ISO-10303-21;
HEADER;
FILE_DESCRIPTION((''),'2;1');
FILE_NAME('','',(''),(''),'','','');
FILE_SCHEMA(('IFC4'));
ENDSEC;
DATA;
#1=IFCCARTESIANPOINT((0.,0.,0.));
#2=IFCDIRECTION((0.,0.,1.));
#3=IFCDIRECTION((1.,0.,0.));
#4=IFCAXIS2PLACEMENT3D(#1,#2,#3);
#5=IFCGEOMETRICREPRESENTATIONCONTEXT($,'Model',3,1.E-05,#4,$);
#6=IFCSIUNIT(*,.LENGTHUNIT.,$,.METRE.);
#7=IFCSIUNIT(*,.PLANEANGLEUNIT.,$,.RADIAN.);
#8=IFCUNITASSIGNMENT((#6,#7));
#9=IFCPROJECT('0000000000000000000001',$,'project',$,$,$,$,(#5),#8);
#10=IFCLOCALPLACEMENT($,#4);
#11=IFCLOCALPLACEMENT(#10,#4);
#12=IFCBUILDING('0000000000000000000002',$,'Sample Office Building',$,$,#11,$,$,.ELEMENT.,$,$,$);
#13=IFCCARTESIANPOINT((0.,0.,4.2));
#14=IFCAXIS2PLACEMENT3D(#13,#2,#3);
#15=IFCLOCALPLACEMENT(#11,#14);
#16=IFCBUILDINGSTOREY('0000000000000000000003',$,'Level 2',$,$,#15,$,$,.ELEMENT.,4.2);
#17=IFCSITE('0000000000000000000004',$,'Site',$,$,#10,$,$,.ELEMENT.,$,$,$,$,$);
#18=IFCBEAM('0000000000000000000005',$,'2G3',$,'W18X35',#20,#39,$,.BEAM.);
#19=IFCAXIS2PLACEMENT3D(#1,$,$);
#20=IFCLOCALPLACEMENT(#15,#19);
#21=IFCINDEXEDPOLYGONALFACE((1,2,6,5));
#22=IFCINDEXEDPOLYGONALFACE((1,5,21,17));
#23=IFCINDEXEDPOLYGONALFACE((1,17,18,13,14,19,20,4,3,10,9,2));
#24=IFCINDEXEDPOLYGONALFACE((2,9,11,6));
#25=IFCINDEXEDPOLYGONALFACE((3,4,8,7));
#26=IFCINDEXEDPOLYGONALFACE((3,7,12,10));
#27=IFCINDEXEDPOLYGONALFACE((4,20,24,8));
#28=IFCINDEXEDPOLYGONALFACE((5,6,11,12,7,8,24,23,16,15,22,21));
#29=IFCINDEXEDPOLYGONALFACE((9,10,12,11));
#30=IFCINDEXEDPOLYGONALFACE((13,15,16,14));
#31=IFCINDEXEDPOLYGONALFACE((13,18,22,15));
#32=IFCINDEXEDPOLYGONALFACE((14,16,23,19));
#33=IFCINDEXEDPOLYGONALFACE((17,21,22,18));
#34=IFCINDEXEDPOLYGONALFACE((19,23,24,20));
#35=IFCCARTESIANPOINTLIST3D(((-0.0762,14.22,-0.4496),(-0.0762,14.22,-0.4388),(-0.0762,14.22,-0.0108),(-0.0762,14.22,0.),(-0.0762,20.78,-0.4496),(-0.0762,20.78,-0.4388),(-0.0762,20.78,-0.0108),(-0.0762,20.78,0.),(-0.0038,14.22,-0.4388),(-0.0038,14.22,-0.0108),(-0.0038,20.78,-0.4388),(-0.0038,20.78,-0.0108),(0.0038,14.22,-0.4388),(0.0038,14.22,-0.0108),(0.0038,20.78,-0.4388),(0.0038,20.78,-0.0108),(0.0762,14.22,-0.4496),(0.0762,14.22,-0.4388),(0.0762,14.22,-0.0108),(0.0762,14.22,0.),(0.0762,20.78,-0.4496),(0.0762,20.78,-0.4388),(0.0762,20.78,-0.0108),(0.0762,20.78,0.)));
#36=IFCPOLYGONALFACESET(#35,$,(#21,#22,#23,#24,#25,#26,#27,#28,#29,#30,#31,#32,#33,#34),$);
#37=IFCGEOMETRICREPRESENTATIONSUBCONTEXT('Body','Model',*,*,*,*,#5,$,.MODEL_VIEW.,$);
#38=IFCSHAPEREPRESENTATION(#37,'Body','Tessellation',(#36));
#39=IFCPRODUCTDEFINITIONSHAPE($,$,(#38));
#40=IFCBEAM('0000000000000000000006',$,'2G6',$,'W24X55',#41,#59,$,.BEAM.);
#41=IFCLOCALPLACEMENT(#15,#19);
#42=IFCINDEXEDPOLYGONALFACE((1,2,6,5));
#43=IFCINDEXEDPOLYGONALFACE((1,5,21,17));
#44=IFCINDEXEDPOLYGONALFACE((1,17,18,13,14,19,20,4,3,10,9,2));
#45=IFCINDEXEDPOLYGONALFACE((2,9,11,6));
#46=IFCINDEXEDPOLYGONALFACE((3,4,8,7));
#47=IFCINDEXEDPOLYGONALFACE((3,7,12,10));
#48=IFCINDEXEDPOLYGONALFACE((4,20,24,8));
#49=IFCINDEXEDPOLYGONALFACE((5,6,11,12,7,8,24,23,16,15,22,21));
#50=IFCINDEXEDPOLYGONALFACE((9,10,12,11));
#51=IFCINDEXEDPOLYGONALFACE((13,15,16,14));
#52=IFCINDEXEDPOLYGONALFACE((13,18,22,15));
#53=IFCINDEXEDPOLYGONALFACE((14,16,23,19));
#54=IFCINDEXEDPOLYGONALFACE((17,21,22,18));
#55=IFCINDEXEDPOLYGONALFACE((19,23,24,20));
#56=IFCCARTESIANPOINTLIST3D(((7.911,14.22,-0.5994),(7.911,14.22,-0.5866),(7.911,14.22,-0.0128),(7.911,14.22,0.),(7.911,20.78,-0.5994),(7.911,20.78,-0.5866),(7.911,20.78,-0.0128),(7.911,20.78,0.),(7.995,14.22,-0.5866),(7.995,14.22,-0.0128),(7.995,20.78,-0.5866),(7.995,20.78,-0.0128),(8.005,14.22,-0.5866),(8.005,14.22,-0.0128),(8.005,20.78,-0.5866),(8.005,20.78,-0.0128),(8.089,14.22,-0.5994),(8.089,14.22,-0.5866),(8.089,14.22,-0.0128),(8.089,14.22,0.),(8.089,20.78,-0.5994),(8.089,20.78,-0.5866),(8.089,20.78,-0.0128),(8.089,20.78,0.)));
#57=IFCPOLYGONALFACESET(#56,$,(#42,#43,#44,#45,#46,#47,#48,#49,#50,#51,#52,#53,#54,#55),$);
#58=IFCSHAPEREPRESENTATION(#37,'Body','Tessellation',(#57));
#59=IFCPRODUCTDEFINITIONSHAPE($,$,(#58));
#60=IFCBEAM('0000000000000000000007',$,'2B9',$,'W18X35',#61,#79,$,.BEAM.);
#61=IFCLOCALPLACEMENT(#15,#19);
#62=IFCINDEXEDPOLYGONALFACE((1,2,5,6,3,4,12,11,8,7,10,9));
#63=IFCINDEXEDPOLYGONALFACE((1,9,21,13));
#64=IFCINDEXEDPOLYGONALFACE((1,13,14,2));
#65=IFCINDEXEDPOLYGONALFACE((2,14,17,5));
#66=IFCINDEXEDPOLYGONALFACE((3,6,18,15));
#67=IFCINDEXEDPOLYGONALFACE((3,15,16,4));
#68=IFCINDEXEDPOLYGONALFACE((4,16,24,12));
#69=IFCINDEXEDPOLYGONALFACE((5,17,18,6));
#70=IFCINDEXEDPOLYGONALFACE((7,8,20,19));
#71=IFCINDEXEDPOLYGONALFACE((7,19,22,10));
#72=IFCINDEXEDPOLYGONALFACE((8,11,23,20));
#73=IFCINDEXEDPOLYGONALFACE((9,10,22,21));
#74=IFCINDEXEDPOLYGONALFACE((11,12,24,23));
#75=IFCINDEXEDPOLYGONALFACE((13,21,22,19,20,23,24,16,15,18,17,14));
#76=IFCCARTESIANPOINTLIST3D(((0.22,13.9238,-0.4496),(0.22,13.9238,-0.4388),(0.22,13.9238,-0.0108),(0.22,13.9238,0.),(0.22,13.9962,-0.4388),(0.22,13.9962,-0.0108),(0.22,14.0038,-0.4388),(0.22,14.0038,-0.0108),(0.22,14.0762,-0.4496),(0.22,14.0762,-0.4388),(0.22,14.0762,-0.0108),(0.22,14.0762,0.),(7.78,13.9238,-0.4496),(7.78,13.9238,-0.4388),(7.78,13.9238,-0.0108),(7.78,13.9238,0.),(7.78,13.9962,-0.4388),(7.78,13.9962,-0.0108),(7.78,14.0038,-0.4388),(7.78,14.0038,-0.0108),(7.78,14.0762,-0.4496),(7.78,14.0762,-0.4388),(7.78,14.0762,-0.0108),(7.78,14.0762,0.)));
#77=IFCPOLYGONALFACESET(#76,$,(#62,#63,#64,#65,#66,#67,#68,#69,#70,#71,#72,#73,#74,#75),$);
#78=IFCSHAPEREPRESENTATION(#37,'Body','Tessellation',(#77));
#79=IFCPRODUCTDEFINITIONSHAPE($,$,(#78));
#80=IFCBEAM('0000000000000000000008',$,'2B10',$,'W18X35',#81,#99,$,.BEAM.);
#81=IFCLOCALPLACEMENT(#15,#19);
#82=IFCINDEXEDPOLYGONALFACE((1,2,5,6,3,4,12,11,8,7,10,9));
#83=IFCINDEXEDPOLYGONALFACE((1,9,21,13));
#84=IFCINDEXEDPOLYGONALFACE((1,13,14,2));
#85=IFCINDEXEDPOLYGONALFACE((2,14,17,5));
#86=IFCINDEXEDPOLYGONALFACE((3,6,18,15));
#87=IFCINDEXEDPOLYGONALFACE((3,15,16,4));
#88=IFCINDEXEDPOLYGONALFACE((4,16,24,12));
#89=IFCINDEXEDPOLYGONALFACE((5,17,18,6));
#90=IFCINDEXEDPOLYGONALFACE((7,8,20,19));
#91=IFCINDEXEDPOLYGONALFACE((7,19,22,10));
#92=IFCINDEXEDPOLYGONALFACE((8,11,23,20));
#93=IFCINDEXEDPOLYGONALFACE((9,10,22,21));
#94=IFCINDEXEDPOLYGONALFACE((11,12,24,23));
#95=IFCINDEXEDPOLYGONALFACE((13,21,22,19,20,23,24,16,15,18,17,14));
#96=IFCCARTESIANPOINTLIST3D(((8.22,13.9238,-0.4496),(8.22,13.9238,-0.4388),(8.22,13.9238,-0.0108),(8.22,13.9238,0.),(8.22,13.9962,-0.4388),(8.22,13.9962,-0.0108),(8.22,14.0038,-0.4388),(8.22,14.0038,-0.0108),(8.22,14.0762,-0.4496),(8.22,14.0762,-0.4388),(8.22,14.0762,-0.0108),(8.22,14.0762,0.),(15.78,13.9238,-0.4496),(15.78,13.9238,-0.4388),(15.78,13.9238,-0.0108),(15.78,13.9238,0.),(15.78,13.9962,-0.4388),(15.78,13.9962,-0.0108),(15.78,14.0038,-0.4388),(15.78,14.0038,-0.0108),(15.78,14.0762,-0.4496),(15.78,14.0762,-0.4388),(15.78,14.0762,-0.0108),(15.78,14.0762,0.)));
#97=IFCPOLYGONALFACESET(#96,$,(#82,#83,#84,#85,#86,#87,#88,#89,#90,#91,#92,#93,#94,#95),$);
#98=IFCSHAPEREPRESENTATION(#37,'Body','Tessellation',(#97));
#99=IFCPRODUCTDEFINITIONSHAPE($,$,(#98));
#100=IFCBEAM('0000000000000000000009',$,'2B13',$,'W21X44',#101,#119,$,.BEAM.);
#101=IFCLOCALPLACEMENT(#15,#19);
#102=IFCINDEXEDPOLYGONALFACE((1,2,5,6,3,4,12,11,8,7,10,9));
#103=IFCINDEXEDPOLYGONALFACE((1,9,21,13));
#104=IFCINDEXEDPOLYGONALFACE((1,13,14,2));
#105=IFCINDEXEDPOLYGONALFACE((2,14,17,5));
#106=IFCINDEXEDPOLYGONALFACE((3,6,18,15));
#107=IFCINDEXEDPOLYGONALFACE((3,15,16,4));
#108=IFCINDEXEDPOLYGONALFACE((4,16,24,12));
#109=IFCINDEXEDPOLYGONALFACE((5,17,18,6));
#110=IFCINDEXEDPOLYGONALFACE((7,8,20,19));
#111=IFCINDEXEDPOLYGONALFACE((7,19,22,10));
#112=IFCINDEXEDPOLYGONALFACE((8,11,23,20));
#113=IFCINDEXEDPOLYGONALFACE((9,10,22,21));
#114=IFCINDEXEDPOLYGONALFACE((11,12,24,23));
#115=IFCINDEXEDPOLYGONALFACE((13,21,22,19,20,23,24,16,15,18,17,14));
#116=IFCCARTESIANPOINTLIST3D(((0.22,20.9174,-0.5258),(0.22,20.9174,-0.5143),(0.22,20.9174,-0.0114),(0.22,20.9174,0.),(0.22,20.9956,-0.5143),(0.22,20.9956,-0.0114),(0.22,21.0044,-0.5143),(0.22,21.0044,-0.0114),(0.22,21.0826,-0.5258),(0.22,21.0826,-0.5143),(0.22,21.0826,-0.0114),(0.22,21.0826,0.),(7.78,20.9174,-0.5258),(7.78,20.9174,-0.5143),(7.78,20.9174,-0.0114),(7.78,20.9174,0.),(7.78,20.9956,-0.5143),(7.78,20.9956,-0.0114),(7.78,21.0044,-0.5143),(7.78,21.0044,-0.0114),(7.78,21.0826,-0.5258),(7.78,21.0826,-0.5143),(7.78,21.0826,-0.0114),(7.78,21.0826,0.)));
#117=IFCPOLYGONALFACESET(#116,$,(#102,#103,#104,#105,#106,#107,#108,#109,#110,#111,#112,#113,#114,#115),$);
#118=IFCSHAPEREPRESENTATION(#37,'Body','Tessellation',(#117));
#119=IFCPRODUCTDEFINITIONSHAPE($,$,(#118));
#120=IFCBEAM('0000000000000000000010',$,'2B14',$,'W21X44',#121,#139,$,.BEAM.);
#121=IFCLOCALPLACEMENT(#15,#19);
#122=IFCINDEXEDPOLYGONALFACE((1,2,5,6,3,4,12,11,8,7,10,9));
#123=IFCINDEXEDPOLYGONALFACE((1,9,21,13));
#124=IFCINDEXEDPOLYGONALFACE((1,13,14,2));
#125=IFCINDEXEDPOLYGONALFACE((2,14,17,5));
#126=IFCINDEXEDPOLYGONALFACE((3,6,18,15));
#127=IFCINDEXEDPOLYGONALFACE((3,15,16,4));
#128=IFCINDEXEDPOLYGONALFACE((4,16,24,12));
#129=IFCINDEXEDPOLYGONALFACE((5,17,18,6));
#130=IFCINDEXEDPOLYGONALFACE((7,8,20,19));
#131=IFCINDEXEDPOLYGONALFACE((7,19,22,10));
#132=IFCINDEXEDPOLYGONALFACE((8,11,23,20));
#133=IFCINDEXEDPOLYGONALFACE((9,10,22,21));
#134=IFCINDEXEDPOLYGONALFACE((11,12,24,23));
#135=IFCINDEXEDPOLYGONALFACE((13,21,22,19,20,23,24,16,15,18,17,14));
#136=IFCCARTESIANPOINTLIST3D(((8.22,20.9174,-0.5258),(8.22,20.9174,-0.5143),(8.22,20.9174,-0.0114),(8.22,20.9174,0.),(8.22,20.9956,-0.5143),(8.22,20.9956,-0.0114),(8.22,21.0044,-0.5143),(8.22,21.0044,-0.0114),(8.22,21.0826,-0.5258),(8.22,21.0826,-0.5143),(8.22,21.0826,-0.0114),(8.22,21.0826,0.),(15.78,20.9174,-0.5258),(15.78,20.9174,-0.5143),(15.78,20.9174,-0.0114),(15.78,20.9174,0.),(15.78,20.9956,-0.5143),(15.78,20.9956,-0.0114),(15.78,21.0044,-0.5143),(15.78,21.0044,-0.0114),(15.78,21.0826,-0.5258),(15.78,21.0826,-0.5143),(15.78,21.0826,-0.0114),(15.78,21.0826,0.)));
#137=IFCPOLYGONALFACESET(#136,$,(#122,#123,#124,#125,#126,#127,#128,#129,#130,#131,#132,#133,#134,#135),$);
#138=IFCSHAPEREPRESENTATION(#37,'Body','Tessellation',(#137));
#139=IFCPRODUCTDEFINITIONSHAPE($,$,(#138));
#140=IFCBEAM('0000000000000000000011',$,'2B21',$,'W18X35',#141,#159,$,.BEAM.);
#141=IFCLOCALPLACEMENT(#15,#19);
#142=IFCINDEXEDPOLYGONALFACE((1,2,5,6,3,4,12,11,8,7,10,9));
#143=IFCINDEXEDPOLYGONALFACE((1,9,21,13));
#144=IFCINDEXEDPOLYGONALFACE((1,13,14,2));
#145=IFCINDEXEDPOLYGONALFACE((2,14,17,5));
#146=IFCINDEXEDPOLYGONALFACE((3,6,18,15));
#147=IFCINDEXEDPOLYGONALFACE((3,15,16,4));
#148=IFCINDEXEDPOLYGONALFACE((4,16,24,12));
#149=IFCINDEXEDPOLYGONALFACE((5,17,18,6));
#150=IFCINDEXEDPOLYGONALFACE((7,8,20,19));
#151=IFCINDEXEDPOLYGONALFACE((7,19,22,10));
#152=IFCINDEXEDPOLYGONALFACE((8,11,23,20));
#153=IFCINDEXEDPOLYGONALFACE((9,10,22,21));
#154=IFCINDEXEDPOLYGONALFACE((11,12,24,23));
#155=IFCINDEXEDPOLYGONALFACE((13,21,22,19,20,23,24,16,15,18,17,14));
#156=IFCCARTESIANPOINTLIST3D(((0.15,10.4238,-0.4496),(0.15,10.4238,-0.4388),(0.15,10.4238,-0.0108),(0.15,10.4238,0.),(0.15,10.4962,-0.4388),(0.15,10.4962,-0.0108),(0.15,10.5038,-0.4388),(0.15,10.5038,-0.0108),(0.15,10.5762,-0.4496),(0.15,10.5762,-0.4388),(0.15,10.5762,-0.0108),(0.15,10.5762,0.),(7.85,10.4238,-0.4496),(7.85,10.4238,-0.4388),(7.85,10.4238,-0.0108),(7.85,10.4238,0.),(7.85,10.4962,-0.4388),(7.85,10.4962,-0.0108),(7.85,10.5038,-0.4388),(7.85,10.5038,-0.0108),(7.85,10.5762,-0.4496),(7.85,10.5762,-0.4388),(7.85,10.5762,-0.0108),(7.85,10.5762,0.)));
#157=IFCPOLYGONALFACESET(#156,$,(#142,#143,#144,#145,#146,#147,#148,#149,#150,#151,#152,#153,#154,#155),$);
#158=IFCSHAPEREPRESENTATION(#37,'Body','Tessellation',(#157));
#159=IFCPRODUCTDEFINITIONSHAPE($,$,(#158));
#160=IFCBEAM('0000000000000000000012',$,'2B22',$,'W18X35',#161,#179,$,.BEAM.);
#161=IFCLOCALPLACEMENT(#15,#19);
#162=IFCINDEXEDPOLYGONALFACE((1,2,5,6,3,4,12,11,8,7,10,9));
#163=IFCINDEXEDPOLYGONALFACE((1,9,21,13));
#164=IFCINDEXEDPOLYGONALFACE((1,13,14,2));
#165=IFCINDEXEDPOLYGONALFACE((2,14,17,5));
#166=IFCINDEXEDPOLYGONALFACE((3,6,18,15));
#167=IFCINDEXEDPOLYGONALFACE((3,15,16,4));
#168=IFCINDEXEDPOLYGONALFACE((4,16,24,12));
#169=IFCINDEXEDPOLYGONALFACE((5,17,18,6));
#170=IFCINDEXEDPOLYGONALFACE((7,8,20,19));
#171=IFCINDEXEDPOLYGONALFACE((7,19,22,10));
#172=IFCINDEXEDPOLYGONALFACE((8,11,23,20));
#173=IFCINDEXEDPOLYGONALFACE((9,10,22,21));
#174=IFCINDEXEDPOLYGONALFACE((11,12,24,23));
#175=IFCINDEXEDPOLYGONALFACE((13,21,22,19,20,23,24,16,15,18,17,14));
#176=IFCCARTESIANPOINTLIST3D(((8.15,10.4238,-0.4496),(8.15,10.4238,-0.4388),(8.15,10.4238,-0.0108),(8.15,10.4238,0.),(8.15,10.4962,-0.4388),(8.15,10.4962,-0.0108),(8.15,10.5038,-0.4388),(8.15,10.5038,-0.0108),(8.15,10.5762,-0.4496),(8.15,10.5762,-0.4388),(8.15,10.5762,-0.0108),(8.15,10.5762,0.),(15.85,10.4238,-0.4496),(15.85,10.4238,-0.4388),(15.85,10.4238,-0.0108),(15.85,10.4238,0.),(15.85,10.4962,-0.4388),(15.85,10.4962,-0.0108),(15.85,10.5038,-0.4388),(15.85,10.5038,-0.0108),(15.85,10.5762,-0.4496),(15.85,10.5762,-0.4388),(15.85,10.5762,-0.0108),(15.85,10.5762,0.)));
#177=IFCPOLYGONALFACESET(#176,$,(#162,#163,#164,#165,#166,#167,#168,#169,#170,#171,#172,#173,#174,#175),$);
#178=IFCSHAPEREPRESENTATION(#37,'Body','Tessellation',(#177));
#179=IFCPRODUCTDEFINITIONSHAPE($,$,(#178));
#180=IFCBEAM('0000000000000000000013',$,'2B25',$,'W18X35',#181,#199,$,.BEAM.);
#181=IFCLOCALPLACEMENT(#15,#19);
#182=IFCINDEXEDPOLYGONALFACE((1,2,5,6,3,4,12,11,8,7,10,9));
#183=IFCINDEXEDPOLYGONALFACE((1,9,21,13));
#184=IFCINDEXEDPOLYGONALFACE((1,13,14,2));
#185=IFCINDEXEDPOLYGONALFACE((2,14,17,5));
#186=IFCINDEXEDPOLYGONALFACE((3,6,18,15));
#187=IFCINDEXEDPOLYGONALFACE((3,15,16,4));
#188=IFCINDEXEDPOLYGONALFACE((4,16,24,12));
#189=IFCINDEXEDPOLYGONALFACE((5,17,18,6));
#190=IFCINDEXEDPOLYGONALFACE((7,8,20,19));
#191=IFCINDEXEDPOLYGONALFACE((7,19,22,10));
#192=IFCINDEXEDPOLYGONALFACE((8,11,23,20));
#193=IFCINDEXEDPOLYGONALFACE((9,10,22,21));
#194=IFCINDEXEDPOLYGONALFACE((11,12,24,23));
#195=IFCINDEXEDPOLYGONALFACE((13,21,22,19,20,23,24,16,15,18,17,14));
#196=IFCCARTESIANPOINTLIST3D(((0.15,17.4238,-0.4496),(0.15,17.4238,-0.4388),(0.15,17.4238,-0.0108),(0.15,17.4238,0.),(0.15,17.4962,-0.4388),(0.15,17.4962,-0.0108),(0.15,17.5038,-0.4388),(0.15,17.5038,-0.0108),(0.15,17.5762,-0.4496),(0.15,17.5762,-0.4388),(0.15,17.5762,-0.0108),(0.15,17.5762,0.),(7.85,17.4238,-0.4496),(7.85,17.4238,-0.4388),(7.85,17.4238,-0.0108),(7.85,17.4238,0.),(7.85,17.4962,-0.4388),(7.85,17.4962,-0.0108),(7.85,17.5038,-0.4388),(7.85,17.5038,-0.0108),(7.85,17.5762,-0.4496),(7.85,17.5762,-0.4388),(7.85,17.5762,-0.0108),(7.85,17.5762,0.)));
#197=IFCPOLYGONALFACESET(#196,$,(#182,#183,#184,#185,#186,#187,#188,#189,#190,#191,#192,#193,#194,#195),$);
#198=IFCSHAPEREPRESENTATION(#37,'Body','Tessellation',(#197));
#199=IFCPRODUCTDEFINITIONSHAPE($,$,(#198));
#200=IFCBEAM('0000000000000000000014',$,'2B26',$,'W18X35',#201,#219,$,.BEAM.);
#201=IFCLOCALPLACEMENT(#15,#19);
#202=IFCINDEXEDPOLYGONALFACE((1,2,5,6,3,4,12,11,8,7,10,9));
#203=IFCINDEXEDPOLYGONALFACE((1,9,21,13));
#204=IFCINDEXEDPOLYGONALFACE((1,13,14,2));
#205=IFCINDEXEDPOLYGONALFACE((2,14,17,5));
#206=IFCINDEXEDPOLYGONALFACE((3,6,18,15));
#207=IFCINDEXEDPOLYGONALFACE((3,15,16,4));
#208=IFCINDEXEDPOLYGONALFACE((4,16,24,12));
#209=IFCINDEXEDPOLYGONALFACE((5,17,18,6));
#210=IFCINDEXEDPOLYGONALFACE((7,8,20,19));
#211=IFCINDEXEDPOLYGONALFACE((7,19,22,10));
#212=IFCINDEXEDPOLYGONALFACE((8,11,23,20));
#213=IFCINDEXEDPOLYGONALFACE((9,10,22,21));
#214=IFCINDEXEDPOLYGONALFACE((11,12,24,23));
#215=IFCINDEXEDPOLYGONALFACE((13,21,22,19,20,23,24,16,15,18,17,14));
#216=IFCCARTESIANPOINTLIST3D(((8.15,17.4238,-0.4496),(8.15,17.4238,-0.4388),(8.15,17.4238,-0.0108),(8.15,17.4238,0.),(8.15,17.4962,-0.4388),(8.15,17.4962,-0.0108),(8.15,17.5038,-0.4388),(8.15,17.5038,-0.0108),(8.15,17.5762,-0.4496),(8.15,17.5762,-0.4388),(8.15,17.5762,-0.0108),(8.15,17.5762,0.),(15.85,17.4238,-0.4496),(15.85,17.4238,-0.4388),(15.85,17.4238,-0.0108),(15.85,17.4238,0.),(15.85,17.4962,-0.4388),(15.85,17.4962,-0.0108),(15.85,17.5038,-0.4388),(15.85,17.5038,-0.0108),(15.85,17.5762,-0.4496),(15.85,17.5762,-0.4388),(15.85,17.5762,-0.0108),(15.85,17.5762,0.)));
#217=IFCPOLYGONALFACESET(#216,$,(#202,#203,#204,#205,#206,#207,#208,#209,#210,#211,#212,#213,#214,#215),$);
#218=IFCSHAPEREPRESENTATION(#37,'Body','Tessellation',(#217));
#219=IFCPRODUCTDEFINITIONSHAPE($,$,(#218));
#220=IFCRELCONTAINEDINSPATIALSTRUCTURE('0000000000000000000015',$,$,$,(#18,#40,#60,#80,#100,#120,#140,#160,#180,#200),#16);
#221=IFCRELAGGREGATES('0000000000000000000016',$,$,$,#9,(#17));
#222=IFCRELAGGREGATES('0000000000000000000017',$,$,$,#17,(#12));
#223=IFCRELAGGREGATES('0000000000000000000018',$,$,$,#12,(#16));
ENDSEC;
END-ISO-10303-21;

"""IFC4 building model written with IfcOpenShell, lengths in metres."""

from ifc_helpers import new_model, si_unit, frame, origin_with_axes, place, context, subcontext, project, spatial, i_section, extrude, element, save


model = new_model("IFC4")

# Units and contexts
model_context = context("Model", 3, precision=1e-05, world=origin_with_axes())
body_context = subcontext(model_context, "Body", "Model", "MODEL_VIEW")
ifc_project = project(units=[si_unit("LENGTHUNIT", "METRE"), si_unit("PLANEANGLEUNIT", "RADIAN")], contexts=[model_context])

# Site, building, storey
site_placement = place(None, origin_with_axes())
site = spatial("IfcSite", under=ifc_project, at=site_placement, Name="Site", CompositionType="ELEMENT")
building_placement = place(site_placement, origin_with_axes())
building = spatial("IfcBuilding", under=site, at=building_placement, Name="Sample Office Building", CompositionType="ELEMENT")
storey_placement = place(building_placement, frame((0.0, 0.0, 4.2), z_axis=(0.0, 0.0, 1.0), x_axis=(1.0, 0.0, 0.0)))
storey = spatial("IfcBuildingStorey", under=building, at=storey_placement, Name="Level 2", CompositionType="ELEMENT", Elevation=4.2)

# Beams
beam_1_placement = place(None, frame((0.0, 14.22, 3.9752), z_axis=(0.0, 1.0, 0.0), x_axis=(-1.0, 0.0, 0.0)))
element("IfcBeam", 1, at=beam_1_placement, inside=storey, Name="2G3", ObjectType="W18X35", PredefinedType="BEAM", context=body_context, shape_type="SweptSolid", body=[
    extrude(i_section(OverallWidth=0.1524, OverallDepth=0.4496, WebThickness=0.0076, FlangeThickness=0.0108), None, (0.0, 0.0, 1.0), 6.56),
])
beam_2_placement = place(None, frame((8.0, 14.22, 3.9003), z_axis=(0.0, 1.0, 0.0), x_axis=(-1.0, 0.0, 0.0)))
element("IfcBeam", 2, at=beam_2_placement, inside=storey, Name="2G6", ObjectType="W24X55", PredefinedType="BEAM", context=body_context, shape_type="SweptSolid", body=[
    extrude(i_section(OverallWidth=0.1781, OverallDepth=0.5994, WebThickness=0.01, FlangeThickness=0.0128), None, (0.0, 0.0, 1.0), 6.56),
])
beam_3_placement = place(None, frame((0.22, 14.0, 3.9752), z_axis=(1.0, 0.0, 0.0), x_axis=(0.0, 1.0, 0.0)))
element("IfcBeam", 3, at=beam_3_placement, inside=storey, Name="2B9", ObjectType="W18X35", PredefinedType="BEAM", context=body_context, shape_type="SweptSolid", body=[
    extrude(i_section(OverallWidth=0.1524, OverallDepth=0.4496, WebThickness=0.0076, FlangeThickness=0.0108), None, (0.0, 0.0, 1.0), 7.56),
])
beam_4_placement = place(None, frame((8.22, 14.0, 3.9752), z_axis=(1.0, 0.0, 0.0), x_axis=(0.0, 1.0, 0.0)))
element("IfcBeam", 4, at=beam_4_placement, inside=storey, Name="2B10", ObjectType="W18X35", PredefinedType="BEAM", context=body_context, shape_type="SweptSolid", body=[
    extrude(i_section(OverallWidth=0.1524, OverallDepth=0.4496, WebThickness=0.0076, FlangeThickness=0.0108), None, (0.0, 0.0, 1.0), 7.56),
])
beam_5_placement = place(None, frame((0.22, 21.0, 3.9371), z_axis=(1.0, 0.0, 0.0), x_axis=(0.0, 1.0, 0.0)))
element("IfcBeam", 5, at=beam_5_placement, inside=storey, Name="2B13", ObjectType="W21X44", PredefinedType="BEAM", context=body_context, shape_type="SweptSolid", body=[
    extrude(i_section(OverallWidth=0.1651, OverallDepth=0.5258, WebThickness=0.0089, FlangeThickness=0.0114), None, (0.0, 0.0, 1.0), 7.56),
])
beam_6_placement = place(None, frame((8.22, 21.0, 3.9371), z_axis=(1.0, 0.0, 0.0), x_axis=(0.0, 1.0, 0.0)))
element("IfcBeam", 6, at=beam_6_placement, inside=storey, Name="2B14", ObjectType="W21X44", PredefinedType="BEAM", context=body_context, shape_type="SweptSolid", body=[
    extrude(i_section(OverallWidth=0.1651, OverallDepth=0.5258, WebThickness=0.0089, FlangeThickness=0.0114), None, (0.0, 0.0, 1.0), 7.56),
])
for number, where, z_axis, x_axis, name in (
    (7, (0.15, 10.5, 3.9752), (1.0, 0.0, 0.0), (0.0, 1.0, 0.0), "2B21"),
    (8, (8.15, 10.5, 3.9752), (1.0, 0.0, 0.0), (0.0, 1.0, 0.0), "2B22"),
    (9, (0.15, 17.5, 3.9752), (1.0, 0.0, 0.0), (0.0, 1.0, 0.0), "2B25"),
    (10, (8.15, 17.5, 3.9752), (1.0, 0.0, 0.0), (0.0, 1.0, 0.0), "2B26"),
):
    element("IfcBeam", number, at=place(None, frame(where, z_axis=z_axis, x_axis=x_axis)), inside=storey, Name=name, ObjectType="W18X35", PredefinedType="BEAM", context=body_context, shape_type="SweptSolid", body=[
        extrude(i_section(OverallWidth=0.1524, OverallDepth=0.4496, WebThickness=0.0076, FlangeThickness=0.0108), None, (0.0, 0.0, 1.0), 7.7),
    ])

save(model, "model.ifc")
